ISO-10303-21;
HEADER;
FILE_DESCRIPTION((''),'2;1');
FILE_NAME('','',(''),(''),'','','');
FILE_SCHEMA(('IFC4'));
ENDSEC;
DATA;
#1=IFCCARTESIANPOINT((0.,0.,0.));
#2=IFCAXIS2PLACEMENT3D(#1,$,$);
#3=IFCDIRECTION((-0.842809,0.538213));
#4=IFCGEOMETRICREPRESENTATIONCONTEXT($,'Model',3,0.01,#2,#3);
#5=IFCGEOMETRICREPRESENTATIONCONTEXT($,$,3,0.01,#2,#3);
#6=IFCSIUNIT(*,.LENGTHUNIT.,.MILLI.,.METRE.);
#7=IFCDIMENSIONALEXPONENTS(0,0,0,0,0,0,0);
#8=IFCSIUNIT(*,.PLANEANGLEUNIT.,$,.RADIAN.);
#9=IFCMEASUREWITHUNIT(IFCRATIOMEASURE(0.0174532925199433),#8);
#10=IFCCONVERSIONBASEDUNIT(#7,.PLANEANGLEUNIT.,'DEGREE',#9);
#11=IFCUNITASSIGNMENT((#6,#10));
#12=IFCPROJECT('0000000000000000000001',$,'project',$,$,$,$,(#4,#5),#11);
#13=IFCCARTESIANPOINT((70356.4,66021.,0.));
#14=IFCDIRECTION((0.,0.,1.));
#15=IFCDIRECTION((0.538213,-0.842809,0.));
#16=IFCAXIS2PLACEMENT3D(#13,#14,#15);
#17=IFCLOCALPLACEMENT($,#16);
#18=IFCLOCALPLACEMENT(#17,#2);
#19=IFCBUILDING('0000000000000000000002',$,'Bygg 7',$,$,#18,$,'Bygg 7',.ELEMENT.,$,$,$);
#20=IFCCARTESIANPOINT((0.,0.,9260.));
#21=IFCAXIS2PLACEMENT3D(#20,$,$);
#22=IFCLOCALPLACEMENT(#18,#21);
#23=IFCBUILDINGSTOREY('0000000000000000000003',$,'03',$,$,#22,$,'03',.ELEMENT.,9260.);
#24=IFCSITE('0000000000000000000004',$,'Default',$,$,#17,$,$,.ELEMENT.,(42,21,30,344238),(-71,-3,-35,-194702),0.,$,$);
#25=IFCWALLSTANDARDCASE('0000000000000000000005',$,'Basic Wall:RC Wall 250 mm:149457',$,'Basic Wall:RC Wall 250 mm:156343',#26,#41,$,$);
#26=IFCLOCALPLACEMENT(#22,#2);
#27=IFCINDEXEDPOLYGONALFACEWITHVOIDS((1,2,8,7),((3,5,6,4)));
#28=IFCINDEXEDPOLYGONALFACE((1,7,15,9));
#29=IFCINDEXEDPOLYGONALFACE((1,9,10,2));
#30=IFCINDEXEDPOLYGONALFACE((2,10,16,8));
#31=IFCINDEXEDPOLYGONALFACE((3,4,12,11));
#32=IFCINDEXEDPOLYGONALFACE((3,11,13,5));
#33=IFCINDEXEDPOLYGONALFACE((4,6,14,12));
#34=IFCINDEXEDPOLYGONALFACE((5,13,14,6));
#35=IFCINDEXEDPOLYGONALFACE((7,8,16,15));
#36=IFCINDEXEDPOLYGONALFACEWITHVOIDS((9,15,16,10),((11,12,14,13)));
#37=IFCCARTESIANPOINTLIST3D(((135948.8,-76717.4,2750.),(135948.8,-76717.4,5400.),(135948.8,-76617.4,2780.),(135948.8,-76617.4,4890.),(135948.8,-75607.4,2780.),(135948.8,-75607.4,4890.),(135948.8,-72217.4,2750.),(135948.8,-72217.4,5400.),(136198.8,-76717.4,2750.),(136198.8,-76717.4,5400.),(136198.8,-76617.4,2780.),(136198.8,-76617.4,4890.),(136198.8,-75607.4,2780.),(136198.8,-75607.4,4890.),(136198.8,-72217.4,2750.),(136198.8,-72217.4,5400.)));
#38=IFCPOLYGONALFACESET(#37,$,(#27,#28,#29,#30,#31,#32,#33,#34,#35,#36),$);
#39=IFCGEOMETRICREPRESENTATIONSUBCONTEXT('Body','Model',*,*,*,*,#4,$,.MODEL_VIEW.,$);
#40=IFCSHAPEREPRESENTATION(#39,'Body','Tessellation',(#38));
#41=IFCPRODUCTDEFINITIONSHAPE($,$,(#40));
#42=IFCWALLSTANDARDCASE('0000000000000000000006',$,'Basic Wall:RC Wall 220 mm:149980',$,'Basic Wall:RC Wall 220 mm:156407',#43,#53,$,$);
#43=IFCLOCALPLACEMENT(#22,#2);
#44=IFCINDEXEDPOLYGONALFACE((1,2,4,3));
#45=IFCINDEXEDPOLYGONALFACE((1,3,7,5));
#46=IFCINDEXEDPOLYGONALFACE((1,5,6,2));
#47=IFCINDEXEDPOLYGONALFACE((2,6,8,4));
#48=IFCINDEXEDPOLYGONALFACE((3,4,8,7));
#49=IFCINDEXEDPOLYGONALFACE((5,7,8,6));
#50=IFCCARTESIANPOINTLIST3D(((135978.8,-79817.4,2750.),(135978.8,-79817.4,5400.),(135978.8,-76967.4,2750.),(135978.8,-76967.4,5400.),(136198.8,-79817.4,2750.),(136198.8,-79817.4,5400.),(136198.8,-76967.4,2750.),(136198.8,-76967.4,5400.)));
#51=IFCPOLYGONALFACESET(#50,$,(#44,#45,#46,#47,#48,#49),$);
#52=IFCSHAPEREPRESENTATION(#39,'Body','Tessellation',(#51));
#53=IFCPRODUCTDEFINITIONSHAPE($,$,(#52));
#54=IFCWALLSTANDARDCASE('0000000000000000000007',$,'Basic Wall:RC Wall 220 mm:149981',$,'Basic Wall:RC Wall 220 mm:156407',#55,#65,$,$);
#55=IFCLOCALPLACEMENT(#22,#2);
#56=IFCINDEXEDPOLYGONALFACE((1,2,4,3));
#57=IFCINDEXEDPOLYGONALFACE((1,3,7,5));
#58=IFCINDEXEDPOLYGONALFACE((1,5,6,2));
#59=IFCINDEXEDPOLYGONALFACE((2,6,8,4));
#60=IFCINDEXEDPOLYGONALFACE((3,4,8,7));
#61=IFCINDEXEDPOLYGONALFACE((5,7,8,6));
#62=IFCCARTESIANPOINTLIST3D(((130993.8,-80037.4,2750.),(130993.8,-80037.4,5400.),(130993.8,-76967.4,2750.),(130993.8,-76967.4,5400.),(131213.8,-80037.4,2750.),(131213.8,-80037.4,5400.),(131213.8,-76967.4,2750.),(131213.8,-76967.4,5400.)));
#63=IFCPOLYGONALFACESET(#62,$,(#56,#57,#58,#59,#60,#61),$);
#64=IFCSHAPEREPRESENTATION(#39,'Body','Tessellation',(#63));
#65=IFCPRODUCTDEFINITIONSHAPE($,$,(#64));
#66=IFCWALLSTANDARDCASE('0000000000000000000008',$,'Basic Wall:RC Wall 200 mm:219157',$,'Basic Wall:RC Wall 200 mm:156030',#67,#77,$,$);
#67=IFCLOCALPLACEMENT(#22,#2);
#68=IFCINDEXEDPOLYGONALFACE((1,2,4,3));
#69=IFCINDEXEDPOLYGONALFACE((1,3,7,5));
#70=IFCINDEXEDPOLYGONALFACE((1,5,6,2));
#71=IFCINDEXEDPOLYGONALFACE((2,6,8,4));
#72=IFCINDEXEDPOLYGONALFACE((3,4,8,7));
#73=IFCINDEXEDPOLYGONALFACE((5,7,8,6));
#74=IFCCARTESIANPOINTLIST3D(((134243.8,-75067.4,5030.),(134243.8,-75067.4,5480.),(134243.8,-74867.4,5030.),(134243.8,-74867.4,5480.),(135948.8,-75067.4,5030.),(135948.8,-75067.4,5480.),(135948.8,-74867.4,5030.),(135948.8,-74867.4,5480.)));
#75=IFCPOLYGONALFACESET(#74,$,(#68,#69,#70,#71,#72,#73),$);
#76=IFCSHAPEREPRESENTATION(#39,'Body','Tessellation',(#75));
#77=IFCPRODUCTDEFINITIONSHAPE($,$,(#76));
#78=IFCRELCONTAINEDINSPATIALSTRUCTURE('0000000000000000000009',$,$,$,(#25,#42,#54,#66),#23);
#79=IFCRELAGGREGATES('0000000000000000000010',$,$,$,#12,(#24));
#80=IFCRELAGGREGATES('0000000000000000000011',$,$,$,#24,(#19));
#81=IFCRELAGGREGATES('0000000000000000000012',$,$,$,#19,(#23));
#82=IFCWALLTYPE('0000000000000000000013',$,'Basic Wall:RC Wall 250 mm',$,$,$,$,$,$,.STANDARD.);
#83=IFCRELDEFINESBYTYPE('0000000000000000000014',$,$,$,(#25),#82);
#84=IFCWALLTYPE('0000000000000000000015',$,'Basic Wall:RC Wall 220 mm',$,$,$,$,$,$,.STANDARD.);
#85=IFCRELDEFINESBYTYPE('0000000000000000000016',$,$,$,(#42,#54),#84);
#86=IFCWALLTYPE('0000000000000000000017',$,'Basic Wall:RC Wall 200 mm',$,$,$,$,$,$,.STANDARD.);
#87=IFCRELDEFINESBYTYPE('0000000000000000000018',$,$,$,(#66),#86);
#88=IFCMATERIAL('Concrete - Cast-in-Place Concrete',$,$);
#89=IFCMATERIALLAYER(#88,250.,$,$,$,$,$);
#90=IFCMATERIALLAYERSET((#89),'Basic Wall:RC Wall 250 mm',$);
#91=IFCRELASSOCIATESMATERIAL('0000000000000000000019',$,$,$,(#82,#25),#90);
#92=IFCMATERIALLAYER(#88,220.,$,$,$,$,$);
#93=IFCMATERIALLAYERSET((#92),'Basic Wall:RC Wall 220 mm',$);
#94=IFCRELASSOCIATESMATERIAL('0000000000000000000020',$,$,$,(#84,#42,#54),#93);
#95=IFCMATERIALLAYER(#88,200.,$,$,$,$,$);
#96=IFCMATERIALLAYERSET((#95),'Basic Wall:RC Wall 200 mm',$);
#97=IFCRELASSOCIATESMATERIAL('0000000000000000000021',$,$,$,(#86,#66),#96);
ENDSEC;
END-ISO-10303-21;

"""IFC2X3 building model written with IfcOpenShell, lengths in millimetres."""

from ifc_helpers import new_model, entity, si_unit, converted_unit, direction, frame, frame_2d, origin, origin_2d_with_axis, place, context, subcontext, project, spatial, polyline, rectangle, extrude, clip, bounded_halfspace, material, layer, layer_set, layer_usage, type_object, element, save


model = new_model("IFC2X3")

# Units and contexts
model_context = context("Model", 3, precision=0.01, world=origin(), true_north=direction((-0.842809, 0.538213)))
context_of_model = context(None, 3, precision=0.01, world=origin(), true_north=direction((-0.842809, 0.538213)))
body_context = subcontext(model_context, "Body", "Model", "MODEL_VIEW")
ifc_project = project(units=[si_unit("LENGTHUNIT", "METRE", prefix="MILLI"), converted_unit("PLANEANGLEUNIT", "DEGREE", entity("IfcRatioMeasure", 0.0174532925199433), si_unit("PLANEANGLEUNIT", "RADIAN"), dimensions=[0, 0, 0, 0, 0, 0, 0])], contexts=[model_context, context_of_model])

# Site, building, storey
site_placement = place(None, frame((70356.4, 66021.0, 0.0), z_axis=(0.0, 0.0, 1.0), x_axis=(0.538213, -0.842809, 0.0)))
site = spatial("IfcSite", under=ifc_project, at=site_placement, Name="Default", CompositionType="ELEMENT", RefLatitude=(42, 21, 30, 344238), RefLongitude=(-71, -3, -35, -194702), RefElevation=0.0)
building_placement = place(site_placement, origin())
building = spatial("IfcBuilding", under=site, at=building_placement, Name="Bygg 7", LongName="Bygg 7", CompositionType="ELEMENT")
storey_placement = place(building_placement, frame((0.0, 0.0, 9260.0)))
storey = spatial("IfcBuildingStorey", under=building, at=storey_placement, Name="03", LongName="03", CompositionType="ELEMENT", Elevation=9260.0)

# Shared definitions
ifc_material_1 = material(Name="Concrete - Cast-in-Place Concrete")

# Wall, opening
ifc_layer_1 = layer(ifc_material_1, 250.0)
ifc_layer_set_1 = layer_set([ifc_layer_1], Name="Basic Wall:RC Wall 250 mm")
ifc_layer_usage_1 = layer_usage(ifc_layer_set_1, "AXIS2", "NEGATIVE", 125.0)
wall_type_1 = type_object("IfcWallType", Name="Basic Wall:RC Wall 250 mm", PredefinedType="STANDARD", material=ifc_layer_set_1)
wall_1_placement = place(storey_placement, frame((136073.8, -76717.4, 2750.0), z_axis=(0.0, 0.0, 1.0), x_axis=(0.0, 1.0, 0.0)))
wall_1 = element("IfcWallStandardCase", 1, at=wall_1_placement, inside=storey, type_object=wall_type_1, material=ifc_layer_usage_1, Name="Basic Wall:RC Wall 250 mm:149457", ObjectType="Basic Wall:RC Wall 250 mm:156343", context=body_context, shape_type="Clipping", body=[
    clip(clip(extrude(rectangle(XDim=4500.0, YDim=250.0, at=frame_2d((2250.0, 0.0), x_axis=(-1.0, 0.0))), origin(), (0.0, 0.0, 1.0), 2650.0), bounded_halfspace(frame((0.0, -125.0, 2650.0), z_axis=(0.0, 0.0, -1.0), x_axis=(-0.99571, -0.092529, 0.0)), True, frame((0.0, -125.0, 2650.0)), polyline([(0.0, 0.0), (4500.0, 0.0), (4500.0, 250.0), (4250.0, 250.0), (0.0, 250.0), (0.0, 0.0)]))), bounded_halfspace(frame((4500.0, -125.0, 0.0), z_axis=(0.0, 0.0, 1.0), x_axis=(0.99571, 0.092529, 0.0)), True, frame((4500.0, -125.0, 0.0)), polyline([(0.0, 0.0), (0.0, 250.0), (-4500.0, 250.0), (-4500.0, 0.0), (0.0, 0.0)]))),
])
opening_1_placement = place(wall_1_placement, origin())
element("IfcOpeningElement", 2, at=opening_1_placement, cuts=wall_1, ObjectType="Opening", context=body_context, shape_type="SweptSolid", body=[
    extrude(rectangle(XDim=2110.0, YDim=1010.0, at=origin_2d_with_axis()), frame((605.0, -125.0, 1085.0), z_axis=(0.0, 1.0, 0.0), x_axis=(0.0, 0.0, -1.0)), (0.0, 0.0, 1.0), 250.0),
])

# Shared definitions
ifc_layer_2 = layer(ifc_material_1, 220.0)
ifc_layer_set_2 = layer_set([ifc_layer_2], Name="Basic Wall:RC Wall 220 mm")
wall_type_2 = type_object("IfcWallType", Name="Basic Wall:RC Wall 220 mm", PredefinedType="STANDARD", material=ifc_layer_set_2)

# Walls
ifc_layer_usage_2 = layer_usage(ifc_layer_set_2, "AXIS2", "NEGATIVE", 110.0)
wall_2_placement = place(storey_placement, frame((136088.8, -79817.4, 2750.0), z_axis=(0.0, 0.0, 1.0), x_axis=(0.0, 1.0, 0.0)))
element("IfcWallStandardCase", 3, at=wall_2_placement, inside=storey, type_object=wall_type_2, material=ifc_layer_usage_2, Name="Basic Wall:RC Wall 220 mm:149980", ObjectType="Basic Wall:RC Wall 220 mm:156407", context=body_context, shape_type="Clipping", body=[
    clip(clip(extrude(rectangle(XDim=2850.0, YDim=220.0, at=frame_2d((1425.0, 0.0), x_axis=(-1.0, 0.0))), origin(), (0.0, 0.0, 1.0), 2650.0), bounded_halfspace(frame((0.0, -110.0, 2650.0), z_axis=(0.0, 0.0, -1.0), x_axis=(-0.99571, -0.092529, 0.0)), True, frame((0.0, -110.0, 2650.0)), polyline([(0.0, 0.0), (2850.0, 0.0), (2850.0, 220.0), (454.0, 220.0), (0.0, 220.0), (0.0, 0.0)]))), bounded_halfspace(frame((2850.0, -110.0, 0.0), z_axis=(0.0, 0.0, 1.0), x_axis=(0.99571, 0.092529, 0.0)), True, frame((2850.0, -110.0, 0.0)), polyline([(0.0, 0.0), (0.0, 220.0), (-2396.0, 220.0), (-2850.0, 220.0), (-2850.0, 0.0), (0.0, 0.0)]))),
])
ifc_layer_usage_3 = layer_usage(ifc_layer_set_2, "AXIS2", "NEGATIVE", 110.0)
wall_3_placement = place(storey_placement, frame((131103.8, -80037.4, 2750.0), z_axis=(0.0, 0.0, 1.0), x_axis=(0.0, 1.0, 0.0)))
element("IfcWallStandardCase", 4, at=wall_3_placement, inside=storey, type_object=wall_type_2, material=ifc_layer_usage_3, Name="Basic Wall:RC Wall 220 mm:149981", ObjectType="Basic Wall:RC Wall 220 mm:156407", context=body_context, shape_type="Clipping", body=[
    clip(clip(extrude(rectangle(XDim=3070.0, YDim=220.0, at=frame_2d((1535.0, 0.0), x_axis=(-1.0, 0.0))), origin(), (0.0, 0.0, 1.0), 2650.0), bounded_halfspace(frame((0.0, -110.0, 2650.0), z_axis=(0.0, 0.0, -1.0), x_axis=(-0.99571, -0.092529, 0.0)), True, frame((0.0, -110.0, 2650.0)), polyline([(0.0, 0.0), (3070.0, 0.0), (3070.0, 220.0), (220.0, 220.0), (0.0, 220.0), (0.0, 0.0)]))), bounded_halfspace(frame((3070.0, -110.0, 0.0), z_axis=(0.0, 0.0, 1.0), x_axis=(0.99571, 0.092529, 0.0)), True, frame((3070.0, -110.0, 0.0)), polyline([(0.0, 0.0), (0.0, 220.0), (-2850.0, 220.0), (-3070.0, 220.0), (-3070.0, 0.0), (0.0, 0.0)]))),
])
ifc_layer_3 = layer(ifc_material_1, 200.0)
ifc_layer_set_3 = layer_set([ifc_layer_3], Name="Basic Wall:RC Wall 200 mm")
ifc_layer_usage_4 = layer_usage(ifc_layer_set_3, "AXIS2", "NEGATIVE", 100.0)
wall_type_3 = type_object("IfcWallType", Name="Basic Wall:RC Wall 200 mm", PredefinedType="STANDARD", material=ifc_layer_set_3)
wall_4_placement = place(storey_placement, frame((134243.8, -74967.4, 5030.0)))
element("IfcWallStandardCase", 5, at=wall_4_placement, inside=storey, type_object=wall_type_3, material=ifc_layer_usage_4, Name="Basic Wall:RC Wall 200 mm:219157", ObjectType="Basic Wall:RC Wall 200 mm:156030", context=body_context, shape_type="Clipping", body=[
    clip(extrude(rectangle(XDim=1705.0, YDim=200.0, at=frame_2d((852.5, 0.0), x_axis=(-1.0, 0.0))), origin(), (0.0, 0.0, 1.0), 450.0), bounded_halfspace(frame((0.0, -100.0, 450.0), z_axis=(0.0, 0.0, -1.0), x_axis=(1.0, 0.0, 0.0)), True, frame((0.0, -100.0, 450.0)), polyline([(0.0, 0.0), (1705.0, 0.0), (1705.0, 200.0), (0.0, 200.0), (0.0, 0.0)]))),
])

save(model, "model.ifc")
